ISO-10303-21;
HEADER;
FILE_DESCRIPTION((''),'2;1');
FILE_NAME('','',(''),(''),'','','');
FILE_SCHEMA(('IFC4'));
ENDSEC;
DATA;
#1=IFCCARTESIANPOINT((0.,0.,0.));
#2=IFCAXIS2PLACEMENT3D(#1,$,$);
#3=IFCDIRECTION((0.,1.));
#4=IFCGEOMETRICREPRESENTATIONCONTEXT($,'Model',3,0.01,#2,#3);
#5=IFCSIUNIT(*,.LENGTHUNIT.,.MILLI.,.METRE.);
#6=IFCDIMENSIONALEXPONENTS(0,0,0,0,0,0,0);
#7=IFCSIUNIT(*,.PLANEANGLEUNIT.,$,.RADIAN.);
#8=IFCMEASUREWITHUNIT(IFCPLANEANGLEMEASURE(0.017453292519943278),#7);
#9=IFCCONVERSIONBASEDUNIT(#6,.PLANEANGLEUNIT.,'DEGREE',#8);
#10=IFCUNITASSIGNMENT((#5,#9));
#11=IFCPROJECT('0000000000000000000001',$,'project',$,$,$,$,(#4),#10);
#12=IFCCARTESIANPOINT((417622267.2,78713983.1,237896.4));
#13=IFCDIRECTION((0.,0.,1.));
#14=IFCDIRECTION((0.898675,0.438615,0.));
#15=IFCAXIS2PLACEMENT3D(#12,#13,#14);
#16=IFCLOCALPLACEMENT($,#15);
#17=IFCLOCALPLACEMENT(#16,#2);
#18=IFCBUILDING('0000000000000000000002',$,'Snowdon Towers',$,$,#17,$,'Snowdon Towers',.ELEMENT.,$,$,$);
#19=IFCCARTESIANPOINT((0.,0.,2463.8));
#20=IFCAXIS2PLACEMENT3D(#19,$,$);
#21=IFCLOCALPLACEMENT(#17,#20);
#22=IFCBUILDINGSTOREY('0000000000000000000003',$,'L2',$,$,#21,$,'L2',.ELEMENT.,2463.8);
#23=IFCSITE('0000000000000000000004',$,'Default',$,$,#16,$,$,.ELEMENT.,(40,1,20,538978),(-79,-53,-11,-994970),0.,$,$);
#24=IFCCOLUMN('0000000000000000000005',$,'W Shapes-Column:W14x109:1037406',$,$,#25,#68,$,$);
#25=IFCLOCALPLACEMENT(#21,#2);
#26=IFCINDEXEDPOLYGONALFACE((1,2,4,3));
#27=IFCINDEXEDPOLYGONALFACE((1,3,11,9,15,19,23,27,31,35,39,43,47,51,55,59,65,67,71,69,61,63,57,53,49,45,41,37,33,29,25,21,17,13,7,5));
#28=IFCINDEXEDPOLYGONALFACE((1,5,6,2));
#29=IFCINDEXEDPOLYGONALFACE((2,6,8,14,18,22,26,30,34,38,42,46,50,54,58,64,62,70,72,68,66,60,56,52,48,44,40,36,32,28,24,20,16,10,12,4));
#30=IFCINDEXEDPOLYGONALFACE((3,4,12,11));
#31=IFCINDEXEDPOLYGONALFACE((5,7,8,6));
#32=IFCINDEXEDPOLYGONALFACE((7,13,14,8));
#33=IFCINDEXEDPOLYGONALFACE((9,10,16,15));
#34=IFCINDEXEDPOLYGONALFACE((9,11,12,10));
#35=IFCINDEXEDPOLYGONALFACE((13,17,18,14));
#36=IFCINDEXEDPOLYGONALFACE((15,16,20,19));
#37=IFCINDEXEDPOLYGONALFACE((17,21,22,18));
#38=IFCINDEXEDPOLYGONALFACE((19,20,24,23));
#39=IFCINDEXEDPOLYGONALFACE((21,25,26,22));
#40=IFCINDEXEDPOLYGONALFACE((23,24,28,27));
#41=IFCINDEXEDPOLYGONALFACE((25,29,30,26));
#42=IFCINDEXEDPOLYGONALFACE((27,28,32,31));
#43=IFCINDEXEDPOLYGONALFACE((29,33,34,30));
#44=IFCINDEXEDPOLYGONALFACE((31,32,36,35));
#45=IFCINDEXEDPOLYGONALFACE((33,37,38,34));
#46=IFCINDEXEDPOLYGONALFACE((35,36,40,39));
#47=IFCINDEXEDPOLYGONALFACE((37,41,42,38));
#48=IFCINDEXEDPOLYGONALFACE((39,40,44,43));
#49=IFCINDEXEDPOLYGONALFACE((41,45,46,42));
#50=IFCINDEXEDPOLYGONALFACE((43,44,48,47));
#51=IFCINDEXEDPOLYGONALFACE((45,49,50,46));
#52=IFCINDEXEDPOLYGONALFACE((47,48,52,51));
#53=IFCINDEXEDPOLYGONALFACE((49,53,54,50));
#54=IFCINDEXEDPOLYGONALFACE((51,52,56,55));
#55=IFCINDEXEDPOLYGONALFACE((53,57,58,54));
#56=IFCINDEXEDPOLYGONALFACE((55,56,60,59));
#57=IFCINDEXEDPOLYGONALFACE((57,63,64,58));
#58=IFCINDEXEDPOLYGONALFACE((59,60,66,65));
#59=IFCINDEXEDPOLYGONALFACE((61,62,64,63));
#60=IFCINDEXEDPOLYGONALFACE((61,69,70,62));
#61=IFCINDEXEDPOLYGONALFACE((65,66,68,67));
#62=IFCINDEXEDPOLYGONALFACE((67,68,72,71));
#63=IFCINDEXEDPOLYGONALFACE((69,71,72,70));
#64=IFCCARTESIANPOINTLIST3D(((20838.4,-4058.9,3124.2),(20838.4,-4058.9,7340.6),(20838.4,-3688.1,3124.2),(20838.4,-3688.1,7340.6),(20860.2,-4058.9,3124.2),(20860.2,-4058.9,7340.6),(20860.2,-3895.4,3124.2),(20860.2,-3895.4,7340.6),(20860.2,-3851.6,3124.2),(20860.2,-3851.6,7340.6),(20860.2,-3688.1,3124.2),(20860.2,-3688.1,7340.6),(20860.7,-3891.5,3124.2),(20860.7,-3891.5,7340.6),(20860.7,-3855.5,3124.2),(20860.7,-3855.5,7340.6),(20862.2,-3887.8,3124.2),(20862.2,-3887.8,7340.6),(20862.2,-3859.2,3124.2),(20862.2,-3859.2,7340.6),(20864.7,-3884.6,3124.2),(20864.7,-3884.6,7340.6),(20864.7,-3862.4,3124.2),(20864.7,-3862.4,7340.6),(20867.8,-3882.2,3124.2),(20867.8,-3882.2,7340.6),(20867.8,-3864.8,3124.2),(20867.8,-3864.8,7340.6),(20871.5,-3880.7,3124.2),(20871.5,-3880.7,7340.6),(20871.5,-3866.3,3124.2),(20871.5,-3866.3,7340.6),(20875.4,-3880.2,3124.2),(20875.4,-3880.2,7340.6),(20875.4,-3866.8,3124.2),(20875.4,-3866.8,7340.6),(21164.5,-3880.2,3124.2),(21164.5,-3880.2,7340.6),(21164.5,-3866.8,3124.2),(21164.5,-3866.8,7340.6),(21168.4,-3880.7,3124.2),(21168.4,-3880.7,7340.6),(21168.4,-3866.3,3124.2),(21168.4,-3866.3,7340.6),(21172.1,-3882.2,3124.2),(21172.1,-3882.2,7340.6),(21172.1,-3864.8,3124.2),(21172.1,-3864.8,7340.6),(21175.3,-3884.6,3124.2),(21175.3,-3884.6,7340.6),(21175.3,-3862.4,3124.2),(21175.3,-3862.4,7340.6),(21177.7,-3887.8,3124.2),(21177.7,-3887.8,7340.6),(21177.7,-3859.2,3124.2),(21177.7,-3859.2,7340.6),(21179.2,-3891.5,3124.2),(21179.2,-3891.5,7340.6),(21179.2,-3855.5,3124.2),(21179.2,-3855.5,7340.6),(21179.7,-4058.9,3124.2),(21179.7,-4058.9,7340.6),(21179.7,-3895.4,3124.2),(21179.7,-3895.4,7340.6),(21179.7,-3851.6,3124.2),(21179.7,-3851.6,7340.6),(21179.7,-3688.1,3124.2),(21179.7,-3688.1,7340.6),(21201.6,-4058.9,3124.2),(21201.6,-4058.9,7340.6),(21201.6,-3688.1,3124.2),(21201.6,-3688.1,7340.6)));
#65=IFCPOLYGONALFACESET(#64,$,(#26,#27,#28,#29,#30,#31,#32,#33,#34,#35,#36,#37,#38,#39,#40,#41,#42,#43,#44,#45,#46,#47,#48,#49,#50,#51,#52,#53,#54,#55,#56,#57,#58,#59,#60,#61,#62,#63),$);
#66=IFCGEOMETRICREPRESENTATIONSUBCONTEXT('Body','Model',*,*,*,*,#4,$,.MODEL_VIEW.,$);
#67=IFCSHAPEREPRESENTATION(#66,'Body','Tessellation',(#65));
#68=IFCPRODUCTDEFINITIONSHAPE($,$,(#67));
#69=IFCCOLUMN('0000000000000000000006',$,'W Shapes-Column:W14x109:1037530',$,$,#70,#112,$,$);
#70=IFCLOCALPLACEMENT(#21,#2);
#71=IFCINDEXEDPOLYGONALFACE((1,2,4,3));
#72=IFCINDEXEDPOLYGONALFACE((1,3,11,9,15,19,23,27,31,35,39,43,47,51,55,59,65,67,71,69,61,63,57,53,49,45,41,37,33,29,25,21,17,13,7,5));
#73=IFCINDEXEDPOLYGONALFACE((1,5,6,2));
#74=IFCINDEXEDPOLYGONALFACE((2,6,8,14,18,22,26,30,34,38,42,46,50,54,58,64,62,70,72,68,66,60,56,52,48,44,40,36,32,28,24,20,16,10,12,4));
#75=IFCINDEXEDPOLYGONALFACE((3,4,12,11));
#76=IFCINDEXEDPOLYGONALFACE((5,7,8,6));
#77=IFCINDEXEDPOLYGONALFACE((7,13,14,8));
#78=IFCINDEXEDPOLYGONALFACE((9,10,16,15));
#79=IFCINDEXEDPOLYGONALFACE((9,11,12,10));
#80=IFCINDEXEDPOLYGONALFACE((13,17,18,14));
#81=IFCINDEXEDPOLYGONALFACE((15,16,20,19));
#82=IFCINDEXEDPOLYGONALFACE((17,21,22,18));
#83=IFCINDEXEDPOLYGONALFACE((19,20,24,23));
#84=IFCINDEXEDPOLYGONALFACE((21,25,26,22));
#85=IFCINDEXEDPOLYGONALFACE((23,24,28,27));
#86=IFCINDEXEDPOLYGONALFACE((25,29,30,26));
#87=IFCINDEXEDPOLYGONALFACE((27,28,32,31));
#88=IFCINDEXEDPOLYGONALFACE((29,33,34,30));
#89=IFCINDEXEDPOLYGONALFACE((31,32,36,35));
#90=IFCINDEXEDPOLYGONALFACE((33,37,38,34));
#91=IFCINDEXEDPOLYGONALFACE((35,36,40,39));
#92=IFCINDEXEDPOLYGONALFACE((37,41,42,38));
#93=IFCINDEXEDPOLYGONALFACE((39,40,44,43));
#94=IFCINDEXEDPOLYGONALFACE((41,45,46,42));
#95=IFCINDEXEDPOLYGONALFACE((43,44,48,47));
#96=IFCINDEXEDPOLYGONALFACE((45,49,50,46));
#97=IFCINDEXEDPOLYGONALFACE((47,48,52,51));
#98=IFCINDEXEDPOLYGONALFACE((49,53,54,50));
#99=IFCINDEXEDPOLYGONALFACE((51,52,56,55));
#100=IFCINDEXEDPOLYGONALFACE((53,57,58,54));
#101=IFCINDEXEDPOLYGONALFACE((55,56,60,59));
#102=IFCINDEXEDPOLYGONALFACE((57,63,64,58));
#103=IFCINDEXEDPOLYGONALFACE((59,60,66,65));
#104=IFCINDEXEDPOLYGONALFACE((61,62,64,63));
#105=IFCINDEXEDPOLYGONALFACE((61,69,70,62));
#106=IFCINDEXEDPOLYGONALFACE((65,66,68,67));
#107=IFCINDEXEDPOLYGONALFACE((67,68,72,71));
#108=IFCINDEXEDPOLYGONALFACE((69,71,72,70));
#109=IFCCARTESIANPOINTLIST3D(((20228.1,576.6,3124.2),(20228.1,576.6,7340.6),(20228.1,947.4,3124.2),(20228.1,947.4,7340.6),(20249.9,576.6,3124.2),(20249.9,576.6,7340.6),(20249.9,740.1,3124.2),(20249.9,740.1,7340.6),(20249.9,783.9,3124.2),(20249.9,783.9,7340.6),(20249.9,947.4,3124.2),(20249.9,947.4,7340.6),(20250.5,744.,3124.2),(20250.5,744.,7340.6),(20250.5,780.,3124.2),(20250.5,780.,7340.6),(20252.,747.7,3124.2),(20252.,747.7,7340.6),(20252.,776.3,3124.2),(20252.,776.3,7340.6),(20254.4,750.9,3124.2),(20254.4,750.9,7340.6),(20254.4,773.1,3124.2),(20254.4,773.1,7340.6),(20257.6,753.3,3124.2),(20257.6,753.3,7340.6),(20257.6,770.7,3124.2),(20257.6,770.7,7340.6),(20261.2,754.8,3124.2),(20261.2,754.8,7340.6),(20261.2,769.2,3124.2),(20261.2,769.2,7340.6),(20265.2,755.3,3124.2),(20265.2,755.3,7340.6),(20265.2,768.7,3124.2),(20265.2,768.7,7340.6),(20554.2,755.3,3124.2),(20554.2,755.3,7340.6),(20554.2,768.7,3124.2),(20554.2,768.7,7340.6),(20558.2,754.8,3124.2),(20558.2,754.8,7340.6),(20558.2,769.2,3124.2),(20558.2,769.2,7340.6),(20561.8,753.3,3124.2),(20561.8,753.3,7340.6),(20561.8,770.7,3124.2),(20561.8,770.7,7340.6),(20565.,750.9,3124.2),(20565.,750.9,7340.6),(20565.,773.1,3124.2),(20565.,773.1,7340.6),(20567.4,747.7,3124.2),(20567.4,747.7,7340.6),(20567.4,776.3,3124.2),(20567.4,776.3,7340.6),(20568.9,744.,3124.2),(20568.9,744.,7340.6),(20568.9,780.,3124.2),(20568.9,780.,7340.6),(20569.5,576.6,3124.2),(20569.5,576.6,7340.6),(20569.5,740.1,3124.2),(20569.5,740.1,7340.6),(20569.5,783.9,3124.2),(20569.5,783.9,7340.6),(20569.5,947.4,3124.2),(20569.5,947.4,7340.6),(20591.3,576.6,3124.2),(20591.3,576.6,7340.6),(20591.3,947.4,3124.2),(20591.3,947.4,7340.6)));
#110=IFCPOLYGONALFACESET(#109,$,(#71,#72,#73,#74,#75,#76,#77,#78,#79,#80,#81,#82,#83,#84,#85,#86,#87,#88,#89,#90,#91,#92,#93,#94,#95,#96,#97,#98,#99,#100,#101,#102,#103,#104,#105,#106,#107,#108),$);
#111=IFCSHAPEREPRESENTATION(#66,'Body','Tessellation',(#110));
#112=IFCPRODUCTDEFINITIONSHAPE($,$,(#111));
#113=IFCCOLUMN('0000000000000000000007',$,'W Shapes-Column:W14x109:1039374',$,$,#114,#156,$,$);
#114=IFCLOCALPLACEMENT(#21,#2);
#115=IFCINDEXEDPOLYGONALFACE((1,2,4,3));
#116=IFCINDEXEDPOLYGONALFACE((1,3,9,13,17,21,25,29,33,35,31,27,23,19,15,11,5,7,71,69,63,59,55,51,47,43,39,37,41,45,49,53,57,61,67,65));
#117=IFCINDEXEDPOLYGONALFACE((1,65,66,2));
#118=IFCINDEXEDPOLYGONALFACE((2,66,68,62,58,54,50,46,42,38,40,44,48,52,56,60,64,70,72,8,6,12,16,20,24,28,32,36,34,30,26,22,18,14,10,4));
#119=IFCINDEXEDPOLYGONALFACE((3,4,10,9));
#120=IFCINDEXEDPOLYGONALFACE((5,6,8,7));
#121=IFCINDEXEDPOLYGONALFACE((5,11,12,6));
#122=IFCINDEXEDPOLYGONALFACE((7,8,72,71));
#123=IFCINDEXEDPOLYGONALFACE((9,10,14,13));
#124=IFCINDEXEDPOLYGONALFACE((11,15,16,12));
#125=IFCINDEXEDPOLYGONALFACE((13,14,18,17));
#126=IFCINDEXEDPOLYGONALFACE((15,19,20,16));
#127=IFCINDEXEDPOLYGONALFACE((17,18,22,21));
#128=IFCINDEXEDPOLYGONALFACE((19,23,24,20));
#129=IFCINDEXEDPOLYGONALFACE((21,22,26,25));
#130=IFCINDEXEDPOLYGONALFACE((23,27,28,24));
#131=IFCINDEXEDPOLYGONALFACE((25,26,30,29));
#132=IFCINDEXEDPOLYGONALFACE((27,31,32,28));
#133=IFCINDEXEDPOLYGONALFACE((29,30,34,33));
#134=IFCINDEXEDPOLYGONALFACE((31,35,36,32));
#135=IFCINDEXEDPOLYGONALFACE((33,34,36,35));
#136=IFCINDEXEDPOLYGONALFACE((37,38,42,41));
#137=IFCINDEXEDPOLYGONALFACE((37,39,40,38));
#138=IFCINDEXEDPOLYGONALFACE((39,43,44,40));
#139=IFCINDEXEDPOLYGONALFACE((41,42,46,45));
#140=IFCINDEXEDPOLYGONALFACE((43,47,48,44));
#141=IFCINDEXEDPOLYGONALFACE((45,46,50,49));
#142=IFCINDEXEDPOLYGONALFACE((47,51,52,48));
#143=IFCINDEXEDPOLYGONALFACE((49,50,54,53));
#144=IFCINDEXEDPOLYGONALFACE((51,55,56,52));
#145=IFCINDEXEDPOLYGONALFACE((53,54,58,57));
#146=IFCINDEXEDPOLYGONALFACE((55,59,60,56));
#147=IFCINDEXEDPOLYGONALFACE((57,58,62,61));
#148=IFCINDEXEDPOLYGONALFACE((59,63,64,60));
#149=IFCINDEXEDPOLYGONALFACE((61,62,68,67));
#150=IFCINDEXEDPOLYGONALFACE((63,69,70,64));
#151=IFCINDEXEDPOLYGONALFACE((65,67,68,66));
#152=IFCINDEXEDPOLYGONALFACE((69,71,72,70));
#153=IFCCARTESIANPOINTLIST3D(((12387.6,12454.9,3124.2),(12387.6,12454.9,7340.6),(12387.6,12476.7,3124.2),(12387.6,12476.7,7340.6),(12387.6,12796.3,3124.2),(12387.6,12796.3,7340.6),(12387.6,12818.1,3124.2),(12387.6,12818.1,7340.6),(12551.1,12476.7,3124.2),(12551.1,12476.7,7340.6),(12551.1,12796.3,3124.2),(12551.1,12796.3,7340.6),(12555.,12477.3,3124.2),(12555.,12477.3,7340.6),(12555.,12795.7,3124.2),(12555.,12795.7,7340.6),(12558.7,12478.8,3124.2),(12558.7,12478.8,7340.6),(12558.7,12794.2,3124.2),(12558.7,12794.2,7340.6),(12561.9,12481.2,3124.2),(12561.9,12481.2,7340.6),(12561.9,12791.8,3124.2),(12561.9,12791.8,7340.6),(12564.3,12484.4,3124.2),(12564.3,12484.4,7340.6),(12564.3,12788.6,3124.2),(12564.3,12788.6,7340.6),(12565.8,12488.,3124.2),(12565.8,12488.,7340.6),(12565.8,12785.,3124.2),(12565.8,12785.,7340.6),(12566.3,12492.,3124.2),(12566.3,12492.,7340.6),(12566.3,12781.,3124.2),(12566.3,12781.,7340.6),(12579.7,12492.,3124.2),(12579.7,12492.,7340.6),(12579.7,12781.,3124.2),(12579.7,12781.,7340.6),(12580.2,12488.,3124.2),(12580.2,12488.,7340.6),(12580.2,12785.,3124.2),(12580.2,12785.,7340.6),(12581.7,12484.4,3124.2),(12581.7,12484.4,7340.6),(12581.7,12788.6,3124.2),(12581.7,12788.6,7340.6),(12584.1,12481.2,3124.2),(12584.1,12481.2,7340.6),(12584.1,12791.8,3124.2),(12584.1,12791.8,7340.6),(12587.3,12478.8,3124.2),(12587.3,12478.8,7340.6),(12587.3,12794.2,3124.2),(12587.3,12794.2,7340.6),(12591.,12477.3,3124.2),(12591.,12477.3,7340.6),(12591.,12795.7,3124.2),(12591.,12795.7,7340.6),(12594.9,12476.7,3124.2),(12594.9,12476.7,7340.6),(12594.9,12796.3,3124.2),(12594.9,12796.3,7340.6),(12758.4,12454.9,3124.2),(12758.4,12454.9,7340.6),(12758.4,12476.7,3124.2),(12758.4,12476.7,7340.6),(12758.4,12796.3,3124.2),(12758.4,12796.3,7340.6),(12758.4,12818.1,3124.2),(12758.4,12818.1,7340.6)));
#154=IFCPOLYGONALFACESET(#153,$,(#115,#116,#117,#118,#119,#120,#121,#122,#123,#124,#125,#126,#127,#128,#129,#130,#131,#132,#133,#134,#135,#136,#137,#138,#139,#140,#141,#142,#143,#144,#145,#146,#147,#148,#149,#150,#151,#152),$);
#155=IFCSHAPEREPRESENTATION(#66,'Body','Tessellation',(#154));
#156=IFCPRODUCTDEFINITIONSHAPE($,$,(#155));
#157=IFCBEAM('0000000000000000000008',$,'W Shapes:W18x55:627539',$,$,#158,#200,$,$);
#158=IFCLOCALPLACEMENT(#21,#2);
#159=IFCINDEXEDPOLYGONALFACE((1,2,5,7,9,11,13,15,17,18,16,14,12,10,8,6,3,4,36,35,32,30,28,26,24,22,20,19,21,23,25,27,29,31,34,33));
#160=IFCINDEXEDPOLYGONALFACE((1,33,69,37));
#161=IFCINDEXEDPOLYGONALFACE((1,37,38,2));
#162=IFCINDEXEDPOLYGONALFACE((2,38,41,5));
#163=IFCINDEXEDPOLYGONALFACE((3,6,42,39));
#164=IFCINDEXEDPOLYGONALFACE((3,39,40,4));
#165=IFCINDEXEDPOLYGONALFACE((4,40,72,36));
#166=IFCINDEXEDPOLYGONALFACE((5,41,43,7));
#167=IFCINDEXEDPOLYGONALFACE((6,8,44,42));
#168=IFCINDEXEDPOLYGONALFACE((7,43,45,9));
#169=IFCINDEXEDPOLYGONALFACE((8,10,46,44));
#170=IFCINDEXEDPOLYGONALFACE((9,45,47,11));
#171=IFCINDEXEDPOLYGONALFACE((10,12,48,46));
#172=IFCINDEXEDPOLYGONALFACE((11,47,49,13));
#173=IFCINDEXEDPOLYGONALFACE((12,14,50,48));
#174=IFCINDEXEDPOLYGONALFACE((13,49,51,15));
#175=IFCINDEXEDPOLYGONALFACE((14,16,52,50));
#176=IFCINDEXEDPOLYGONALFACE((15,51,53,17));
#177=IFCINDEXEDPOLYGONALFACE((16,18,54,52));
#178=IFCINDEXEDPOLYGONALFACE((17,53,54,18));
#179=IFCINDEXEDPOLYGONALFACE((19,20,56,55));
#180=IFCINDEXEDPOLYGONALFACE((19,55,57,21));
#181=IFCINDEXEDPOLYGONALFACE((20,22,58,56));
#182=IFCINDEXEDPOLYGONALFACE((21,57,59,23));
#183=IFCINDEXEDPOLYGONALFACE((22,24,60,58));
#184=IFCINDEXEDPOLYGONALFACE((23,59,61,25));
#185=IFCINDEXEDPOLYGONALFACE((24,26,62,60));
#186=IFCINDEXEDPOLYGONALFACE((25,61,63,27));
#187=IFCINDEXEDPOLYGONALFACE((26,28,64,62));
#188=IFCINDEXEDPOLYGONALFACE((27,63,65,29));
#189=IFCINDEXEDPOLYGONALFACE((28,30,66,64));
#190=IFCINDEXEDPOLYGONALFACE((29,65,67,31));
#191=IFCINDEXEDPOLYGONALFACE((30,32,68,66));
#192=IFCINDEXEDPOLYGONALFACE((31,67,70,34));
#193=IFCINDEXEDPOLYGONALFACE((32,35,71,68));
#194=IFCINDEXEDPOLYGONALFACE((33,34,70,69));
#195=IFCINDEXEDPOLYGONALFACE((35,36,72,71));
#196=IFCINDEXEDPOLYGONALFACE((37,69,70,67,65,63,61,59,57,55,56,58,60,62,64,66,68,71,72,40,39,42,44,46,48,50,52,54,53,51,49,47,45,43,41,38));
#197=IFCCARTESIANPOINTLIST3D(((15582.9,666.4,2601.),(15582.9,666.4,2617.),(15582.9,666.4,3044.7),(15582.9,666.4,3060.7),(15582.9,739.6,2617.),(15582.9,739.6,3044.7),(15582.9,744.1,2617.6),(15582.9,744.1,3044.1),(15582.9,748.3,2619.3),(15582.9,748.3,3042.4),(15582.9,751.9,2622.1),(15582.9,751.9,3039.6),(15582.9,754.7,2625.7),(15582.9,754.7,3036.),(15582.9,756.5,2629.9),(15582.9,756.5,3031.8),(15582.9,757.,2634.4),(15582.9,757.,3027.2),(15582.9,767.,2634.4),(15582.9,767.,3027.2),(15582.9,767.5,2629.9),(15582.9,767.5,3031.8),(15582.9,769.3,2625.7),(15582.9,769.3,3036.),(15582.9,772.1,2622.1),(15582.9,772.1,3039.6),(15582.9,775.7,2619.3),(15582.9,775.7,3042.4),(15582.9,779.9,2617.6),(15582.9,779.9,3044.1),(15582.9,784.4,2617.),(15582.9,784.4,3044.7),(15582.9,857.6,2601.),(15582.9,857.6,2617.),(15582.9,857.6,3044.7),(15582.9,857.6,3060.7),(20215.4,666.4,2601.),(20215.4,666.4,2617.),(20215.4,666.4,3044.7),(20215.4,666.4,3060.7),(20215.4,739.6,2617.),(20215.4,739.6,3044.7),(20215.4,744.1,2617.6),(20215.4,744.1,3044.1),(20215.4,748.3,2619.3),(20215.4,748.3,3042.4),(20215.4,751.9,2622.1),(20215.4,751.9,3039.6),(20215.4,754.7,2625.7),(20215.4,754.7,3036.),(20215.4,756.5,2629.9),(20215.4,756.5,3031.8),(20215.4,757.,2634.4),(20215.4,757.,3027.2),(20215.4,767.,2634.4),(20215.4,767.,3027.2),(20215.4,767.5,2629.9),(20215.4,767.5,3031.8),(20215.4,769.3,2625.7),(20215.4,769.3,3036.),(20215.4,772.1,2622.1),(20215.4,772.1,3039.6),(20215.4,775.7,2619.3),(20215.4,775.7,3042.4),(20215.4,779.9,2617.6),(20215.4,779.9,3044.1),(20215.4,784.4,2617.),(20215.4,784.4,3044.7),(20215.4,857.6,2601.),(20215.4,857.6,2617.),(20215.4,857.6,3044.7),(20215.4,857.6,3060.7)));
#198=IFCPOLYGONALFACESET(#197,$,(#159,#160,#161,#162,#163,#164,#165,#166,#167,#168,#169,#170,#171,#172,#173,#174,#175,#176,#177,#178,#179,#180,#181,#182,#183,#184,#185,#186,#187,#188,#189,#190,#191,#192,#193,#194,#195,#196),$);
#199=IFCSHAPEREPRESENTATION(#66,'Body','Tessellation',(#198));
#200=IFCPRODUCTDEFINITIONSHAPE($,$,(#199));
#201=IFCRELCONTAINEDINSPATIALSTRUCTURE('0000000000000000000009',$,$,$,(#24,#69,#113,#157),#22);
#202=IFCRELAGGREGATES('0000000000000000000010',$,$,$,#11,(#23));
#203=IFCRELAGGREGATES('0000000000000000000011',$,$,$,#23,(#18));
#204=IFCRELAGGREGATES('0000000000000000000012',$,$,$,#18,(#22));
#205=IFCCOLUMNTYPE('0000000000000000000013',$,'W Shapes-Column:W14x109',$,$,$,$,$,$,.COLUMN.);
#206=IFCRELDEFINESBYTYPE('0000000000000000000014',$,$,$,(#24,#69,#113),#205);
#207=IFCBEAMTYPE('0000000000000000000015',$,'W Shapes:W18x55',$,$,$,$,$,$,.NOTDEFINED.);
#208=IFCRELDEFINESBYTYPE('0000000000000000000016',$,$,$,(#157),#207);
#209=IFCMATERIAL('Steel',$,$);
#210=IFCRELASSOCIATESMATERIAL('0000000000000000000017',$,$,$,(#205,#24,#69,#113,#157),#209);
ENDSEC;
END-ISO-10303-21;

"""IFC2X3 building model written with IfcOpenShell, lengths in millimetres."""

from ifc_helpers import new_model, entity, si_unit, converted_unit, direction, frame, frame_2d, origin, place, context, subcontext, project, spatial, i_section, extrude, source, transform, mapped, material, type_object, type_shapes, element, save


model = new_model("IFC2X3")

# Units and contexts
model_context = context("Model", 3, precision=0.01, world=origin(), true_north=direction((0.0, 1.0)))
body_context = subcontext(model_context, "Body", "Model", "MODEL_VIEW")
ifc_project = project(units=[si_unit("LENGTHUNIT", "METRE", prefix="MILLI"), converted_unit("PLANEANGLEUNIT", "DEGREE", entity("IfcPlaneAngleMeasure", 0.017453292519943278), si_unit("PLANEANGLEUNIT", "RADIAN"), dimensions=[0, 0, 0, 0, 0, 0, 0])], contexts=[model_context])

# Site, building, storey
site_placement = place(None, frame((417622267.2, 78713983.1, 237896.4), z_axis=(0.0, 0.0, 1.0), x_axis=(0.898675, 0.438615, 0.0)))
site = spatial("IfcSite", under=ifc_project, at=site_placement, Name="Default", CompositionType="ELEMENT", RefLatitude=(40, 1, 20, 538978), RefLongitude=(-79, -53, -11, -994970), RefElevation=0.0)
building_placement = place(site_placement, origin())
building = spatial("IfcBuilding", under=site, at=building_placement, Name="Snowdon Towers", LongName="Snowdon Towers", CompositionType="ELEMENT")
storey_placement = place(building_placement, frame((0.0, 0.0, 2463.8)))
storey = spatial("IfcBuildingStorey", under=building, at=storey_placement, Name="L2", LongName="L2", CompositionType="ELEMENT", Elevation=2463.8)

# Columns
ifc_material_1 = material(Name="Steel")
column_type = type_object("IfcColumnType", Name="W Shapes-Column:W14x109", PredefinedType="COLUMN", material=ifc_material_1)
shared_shape = source(origin(), body_context, "Body", "SweptSolid", [
    extrude(i_section(OverallWidth=370.8, OverallDepth=363.2, WebThickness=13.3, FlangeThickness=21.8, FilletRadius=15.2, at=frame_2d((0.0, 0.0), x_axis=(1.0, 0.0))), frame((0.0, 0.0, 5588.0), z_axis=(0.0, 0.0, 1.0), x_axis=(-1.0, 0.0, 0.0)), (0.0, 0.0, 1.0), 4216.4),
])
type_shapes(column_type, [shared_shape])
for number, where, z_axis, x_axis, name in (
    (1, (21020.0, -3873.5, -2463.8), (0.0, 0.0, 1.0), (0.0, 1.0, 0.0), "W Shapes-Column:W14x109:1037406"),
    (2, (20409.7, 762.0, -2463.8), (0.0, 0.0, 1.0), (0.0, 1.0, 0.0), "W Shapes-Column:W14x109:1037530"),
    (3, (12573.0, 12636.5, -2463.8), (0.0, 0.0, 1.0), (-1.0, 0.0, 0.0), "W Shapes-Column:W14x109:1039374"),
):
    element("IfcColumn", number, at=place(storey_placement, frame(where, z_axis=z_axis, x_axis=x_axis)), inside=storey, type_object=column_type, material=ifc_material_1, Name=name, context=body_context, shape_type="MappedRepresentation", body=[
        mapped(shared_shape, transform((0.0, 0.0, 0.0), scale=1.0)),
    ])

# Beam
beam_type_1 = type_object("IfcBeamType", Name="W Shapes:W18x55", PredefinedType="NOTDEFINED")
beam_1_placement = place(storey_placement, frame((15582.9, 762.0, 3124.2)))
element("IfcBeam", 4, at=beam_1_placement, inside=storey, type_object=beam_type_1, material=ifc_material_1, Name="W Shapes:W18x55:627539", context=body_context, shape_type="SweptSolid", body=[
    extrude(i_section(OverallWidth=191.3, OverallDepth=459.7, WebThickness=9.9, FlangeThickness=16.0, FilletRadius=17.5, at=frame_2d((0.0, 0.0), x_axis=(0.0, 1.0))), frame((0.0, 0.0, -293.4), z_axis=(1.0, 0.0, 0.0), x_axis=(0.0, 0.0, -1.0)), (0.0, 0.0, 1.0), 4632.5),
])

save(model, "model.ifc")
